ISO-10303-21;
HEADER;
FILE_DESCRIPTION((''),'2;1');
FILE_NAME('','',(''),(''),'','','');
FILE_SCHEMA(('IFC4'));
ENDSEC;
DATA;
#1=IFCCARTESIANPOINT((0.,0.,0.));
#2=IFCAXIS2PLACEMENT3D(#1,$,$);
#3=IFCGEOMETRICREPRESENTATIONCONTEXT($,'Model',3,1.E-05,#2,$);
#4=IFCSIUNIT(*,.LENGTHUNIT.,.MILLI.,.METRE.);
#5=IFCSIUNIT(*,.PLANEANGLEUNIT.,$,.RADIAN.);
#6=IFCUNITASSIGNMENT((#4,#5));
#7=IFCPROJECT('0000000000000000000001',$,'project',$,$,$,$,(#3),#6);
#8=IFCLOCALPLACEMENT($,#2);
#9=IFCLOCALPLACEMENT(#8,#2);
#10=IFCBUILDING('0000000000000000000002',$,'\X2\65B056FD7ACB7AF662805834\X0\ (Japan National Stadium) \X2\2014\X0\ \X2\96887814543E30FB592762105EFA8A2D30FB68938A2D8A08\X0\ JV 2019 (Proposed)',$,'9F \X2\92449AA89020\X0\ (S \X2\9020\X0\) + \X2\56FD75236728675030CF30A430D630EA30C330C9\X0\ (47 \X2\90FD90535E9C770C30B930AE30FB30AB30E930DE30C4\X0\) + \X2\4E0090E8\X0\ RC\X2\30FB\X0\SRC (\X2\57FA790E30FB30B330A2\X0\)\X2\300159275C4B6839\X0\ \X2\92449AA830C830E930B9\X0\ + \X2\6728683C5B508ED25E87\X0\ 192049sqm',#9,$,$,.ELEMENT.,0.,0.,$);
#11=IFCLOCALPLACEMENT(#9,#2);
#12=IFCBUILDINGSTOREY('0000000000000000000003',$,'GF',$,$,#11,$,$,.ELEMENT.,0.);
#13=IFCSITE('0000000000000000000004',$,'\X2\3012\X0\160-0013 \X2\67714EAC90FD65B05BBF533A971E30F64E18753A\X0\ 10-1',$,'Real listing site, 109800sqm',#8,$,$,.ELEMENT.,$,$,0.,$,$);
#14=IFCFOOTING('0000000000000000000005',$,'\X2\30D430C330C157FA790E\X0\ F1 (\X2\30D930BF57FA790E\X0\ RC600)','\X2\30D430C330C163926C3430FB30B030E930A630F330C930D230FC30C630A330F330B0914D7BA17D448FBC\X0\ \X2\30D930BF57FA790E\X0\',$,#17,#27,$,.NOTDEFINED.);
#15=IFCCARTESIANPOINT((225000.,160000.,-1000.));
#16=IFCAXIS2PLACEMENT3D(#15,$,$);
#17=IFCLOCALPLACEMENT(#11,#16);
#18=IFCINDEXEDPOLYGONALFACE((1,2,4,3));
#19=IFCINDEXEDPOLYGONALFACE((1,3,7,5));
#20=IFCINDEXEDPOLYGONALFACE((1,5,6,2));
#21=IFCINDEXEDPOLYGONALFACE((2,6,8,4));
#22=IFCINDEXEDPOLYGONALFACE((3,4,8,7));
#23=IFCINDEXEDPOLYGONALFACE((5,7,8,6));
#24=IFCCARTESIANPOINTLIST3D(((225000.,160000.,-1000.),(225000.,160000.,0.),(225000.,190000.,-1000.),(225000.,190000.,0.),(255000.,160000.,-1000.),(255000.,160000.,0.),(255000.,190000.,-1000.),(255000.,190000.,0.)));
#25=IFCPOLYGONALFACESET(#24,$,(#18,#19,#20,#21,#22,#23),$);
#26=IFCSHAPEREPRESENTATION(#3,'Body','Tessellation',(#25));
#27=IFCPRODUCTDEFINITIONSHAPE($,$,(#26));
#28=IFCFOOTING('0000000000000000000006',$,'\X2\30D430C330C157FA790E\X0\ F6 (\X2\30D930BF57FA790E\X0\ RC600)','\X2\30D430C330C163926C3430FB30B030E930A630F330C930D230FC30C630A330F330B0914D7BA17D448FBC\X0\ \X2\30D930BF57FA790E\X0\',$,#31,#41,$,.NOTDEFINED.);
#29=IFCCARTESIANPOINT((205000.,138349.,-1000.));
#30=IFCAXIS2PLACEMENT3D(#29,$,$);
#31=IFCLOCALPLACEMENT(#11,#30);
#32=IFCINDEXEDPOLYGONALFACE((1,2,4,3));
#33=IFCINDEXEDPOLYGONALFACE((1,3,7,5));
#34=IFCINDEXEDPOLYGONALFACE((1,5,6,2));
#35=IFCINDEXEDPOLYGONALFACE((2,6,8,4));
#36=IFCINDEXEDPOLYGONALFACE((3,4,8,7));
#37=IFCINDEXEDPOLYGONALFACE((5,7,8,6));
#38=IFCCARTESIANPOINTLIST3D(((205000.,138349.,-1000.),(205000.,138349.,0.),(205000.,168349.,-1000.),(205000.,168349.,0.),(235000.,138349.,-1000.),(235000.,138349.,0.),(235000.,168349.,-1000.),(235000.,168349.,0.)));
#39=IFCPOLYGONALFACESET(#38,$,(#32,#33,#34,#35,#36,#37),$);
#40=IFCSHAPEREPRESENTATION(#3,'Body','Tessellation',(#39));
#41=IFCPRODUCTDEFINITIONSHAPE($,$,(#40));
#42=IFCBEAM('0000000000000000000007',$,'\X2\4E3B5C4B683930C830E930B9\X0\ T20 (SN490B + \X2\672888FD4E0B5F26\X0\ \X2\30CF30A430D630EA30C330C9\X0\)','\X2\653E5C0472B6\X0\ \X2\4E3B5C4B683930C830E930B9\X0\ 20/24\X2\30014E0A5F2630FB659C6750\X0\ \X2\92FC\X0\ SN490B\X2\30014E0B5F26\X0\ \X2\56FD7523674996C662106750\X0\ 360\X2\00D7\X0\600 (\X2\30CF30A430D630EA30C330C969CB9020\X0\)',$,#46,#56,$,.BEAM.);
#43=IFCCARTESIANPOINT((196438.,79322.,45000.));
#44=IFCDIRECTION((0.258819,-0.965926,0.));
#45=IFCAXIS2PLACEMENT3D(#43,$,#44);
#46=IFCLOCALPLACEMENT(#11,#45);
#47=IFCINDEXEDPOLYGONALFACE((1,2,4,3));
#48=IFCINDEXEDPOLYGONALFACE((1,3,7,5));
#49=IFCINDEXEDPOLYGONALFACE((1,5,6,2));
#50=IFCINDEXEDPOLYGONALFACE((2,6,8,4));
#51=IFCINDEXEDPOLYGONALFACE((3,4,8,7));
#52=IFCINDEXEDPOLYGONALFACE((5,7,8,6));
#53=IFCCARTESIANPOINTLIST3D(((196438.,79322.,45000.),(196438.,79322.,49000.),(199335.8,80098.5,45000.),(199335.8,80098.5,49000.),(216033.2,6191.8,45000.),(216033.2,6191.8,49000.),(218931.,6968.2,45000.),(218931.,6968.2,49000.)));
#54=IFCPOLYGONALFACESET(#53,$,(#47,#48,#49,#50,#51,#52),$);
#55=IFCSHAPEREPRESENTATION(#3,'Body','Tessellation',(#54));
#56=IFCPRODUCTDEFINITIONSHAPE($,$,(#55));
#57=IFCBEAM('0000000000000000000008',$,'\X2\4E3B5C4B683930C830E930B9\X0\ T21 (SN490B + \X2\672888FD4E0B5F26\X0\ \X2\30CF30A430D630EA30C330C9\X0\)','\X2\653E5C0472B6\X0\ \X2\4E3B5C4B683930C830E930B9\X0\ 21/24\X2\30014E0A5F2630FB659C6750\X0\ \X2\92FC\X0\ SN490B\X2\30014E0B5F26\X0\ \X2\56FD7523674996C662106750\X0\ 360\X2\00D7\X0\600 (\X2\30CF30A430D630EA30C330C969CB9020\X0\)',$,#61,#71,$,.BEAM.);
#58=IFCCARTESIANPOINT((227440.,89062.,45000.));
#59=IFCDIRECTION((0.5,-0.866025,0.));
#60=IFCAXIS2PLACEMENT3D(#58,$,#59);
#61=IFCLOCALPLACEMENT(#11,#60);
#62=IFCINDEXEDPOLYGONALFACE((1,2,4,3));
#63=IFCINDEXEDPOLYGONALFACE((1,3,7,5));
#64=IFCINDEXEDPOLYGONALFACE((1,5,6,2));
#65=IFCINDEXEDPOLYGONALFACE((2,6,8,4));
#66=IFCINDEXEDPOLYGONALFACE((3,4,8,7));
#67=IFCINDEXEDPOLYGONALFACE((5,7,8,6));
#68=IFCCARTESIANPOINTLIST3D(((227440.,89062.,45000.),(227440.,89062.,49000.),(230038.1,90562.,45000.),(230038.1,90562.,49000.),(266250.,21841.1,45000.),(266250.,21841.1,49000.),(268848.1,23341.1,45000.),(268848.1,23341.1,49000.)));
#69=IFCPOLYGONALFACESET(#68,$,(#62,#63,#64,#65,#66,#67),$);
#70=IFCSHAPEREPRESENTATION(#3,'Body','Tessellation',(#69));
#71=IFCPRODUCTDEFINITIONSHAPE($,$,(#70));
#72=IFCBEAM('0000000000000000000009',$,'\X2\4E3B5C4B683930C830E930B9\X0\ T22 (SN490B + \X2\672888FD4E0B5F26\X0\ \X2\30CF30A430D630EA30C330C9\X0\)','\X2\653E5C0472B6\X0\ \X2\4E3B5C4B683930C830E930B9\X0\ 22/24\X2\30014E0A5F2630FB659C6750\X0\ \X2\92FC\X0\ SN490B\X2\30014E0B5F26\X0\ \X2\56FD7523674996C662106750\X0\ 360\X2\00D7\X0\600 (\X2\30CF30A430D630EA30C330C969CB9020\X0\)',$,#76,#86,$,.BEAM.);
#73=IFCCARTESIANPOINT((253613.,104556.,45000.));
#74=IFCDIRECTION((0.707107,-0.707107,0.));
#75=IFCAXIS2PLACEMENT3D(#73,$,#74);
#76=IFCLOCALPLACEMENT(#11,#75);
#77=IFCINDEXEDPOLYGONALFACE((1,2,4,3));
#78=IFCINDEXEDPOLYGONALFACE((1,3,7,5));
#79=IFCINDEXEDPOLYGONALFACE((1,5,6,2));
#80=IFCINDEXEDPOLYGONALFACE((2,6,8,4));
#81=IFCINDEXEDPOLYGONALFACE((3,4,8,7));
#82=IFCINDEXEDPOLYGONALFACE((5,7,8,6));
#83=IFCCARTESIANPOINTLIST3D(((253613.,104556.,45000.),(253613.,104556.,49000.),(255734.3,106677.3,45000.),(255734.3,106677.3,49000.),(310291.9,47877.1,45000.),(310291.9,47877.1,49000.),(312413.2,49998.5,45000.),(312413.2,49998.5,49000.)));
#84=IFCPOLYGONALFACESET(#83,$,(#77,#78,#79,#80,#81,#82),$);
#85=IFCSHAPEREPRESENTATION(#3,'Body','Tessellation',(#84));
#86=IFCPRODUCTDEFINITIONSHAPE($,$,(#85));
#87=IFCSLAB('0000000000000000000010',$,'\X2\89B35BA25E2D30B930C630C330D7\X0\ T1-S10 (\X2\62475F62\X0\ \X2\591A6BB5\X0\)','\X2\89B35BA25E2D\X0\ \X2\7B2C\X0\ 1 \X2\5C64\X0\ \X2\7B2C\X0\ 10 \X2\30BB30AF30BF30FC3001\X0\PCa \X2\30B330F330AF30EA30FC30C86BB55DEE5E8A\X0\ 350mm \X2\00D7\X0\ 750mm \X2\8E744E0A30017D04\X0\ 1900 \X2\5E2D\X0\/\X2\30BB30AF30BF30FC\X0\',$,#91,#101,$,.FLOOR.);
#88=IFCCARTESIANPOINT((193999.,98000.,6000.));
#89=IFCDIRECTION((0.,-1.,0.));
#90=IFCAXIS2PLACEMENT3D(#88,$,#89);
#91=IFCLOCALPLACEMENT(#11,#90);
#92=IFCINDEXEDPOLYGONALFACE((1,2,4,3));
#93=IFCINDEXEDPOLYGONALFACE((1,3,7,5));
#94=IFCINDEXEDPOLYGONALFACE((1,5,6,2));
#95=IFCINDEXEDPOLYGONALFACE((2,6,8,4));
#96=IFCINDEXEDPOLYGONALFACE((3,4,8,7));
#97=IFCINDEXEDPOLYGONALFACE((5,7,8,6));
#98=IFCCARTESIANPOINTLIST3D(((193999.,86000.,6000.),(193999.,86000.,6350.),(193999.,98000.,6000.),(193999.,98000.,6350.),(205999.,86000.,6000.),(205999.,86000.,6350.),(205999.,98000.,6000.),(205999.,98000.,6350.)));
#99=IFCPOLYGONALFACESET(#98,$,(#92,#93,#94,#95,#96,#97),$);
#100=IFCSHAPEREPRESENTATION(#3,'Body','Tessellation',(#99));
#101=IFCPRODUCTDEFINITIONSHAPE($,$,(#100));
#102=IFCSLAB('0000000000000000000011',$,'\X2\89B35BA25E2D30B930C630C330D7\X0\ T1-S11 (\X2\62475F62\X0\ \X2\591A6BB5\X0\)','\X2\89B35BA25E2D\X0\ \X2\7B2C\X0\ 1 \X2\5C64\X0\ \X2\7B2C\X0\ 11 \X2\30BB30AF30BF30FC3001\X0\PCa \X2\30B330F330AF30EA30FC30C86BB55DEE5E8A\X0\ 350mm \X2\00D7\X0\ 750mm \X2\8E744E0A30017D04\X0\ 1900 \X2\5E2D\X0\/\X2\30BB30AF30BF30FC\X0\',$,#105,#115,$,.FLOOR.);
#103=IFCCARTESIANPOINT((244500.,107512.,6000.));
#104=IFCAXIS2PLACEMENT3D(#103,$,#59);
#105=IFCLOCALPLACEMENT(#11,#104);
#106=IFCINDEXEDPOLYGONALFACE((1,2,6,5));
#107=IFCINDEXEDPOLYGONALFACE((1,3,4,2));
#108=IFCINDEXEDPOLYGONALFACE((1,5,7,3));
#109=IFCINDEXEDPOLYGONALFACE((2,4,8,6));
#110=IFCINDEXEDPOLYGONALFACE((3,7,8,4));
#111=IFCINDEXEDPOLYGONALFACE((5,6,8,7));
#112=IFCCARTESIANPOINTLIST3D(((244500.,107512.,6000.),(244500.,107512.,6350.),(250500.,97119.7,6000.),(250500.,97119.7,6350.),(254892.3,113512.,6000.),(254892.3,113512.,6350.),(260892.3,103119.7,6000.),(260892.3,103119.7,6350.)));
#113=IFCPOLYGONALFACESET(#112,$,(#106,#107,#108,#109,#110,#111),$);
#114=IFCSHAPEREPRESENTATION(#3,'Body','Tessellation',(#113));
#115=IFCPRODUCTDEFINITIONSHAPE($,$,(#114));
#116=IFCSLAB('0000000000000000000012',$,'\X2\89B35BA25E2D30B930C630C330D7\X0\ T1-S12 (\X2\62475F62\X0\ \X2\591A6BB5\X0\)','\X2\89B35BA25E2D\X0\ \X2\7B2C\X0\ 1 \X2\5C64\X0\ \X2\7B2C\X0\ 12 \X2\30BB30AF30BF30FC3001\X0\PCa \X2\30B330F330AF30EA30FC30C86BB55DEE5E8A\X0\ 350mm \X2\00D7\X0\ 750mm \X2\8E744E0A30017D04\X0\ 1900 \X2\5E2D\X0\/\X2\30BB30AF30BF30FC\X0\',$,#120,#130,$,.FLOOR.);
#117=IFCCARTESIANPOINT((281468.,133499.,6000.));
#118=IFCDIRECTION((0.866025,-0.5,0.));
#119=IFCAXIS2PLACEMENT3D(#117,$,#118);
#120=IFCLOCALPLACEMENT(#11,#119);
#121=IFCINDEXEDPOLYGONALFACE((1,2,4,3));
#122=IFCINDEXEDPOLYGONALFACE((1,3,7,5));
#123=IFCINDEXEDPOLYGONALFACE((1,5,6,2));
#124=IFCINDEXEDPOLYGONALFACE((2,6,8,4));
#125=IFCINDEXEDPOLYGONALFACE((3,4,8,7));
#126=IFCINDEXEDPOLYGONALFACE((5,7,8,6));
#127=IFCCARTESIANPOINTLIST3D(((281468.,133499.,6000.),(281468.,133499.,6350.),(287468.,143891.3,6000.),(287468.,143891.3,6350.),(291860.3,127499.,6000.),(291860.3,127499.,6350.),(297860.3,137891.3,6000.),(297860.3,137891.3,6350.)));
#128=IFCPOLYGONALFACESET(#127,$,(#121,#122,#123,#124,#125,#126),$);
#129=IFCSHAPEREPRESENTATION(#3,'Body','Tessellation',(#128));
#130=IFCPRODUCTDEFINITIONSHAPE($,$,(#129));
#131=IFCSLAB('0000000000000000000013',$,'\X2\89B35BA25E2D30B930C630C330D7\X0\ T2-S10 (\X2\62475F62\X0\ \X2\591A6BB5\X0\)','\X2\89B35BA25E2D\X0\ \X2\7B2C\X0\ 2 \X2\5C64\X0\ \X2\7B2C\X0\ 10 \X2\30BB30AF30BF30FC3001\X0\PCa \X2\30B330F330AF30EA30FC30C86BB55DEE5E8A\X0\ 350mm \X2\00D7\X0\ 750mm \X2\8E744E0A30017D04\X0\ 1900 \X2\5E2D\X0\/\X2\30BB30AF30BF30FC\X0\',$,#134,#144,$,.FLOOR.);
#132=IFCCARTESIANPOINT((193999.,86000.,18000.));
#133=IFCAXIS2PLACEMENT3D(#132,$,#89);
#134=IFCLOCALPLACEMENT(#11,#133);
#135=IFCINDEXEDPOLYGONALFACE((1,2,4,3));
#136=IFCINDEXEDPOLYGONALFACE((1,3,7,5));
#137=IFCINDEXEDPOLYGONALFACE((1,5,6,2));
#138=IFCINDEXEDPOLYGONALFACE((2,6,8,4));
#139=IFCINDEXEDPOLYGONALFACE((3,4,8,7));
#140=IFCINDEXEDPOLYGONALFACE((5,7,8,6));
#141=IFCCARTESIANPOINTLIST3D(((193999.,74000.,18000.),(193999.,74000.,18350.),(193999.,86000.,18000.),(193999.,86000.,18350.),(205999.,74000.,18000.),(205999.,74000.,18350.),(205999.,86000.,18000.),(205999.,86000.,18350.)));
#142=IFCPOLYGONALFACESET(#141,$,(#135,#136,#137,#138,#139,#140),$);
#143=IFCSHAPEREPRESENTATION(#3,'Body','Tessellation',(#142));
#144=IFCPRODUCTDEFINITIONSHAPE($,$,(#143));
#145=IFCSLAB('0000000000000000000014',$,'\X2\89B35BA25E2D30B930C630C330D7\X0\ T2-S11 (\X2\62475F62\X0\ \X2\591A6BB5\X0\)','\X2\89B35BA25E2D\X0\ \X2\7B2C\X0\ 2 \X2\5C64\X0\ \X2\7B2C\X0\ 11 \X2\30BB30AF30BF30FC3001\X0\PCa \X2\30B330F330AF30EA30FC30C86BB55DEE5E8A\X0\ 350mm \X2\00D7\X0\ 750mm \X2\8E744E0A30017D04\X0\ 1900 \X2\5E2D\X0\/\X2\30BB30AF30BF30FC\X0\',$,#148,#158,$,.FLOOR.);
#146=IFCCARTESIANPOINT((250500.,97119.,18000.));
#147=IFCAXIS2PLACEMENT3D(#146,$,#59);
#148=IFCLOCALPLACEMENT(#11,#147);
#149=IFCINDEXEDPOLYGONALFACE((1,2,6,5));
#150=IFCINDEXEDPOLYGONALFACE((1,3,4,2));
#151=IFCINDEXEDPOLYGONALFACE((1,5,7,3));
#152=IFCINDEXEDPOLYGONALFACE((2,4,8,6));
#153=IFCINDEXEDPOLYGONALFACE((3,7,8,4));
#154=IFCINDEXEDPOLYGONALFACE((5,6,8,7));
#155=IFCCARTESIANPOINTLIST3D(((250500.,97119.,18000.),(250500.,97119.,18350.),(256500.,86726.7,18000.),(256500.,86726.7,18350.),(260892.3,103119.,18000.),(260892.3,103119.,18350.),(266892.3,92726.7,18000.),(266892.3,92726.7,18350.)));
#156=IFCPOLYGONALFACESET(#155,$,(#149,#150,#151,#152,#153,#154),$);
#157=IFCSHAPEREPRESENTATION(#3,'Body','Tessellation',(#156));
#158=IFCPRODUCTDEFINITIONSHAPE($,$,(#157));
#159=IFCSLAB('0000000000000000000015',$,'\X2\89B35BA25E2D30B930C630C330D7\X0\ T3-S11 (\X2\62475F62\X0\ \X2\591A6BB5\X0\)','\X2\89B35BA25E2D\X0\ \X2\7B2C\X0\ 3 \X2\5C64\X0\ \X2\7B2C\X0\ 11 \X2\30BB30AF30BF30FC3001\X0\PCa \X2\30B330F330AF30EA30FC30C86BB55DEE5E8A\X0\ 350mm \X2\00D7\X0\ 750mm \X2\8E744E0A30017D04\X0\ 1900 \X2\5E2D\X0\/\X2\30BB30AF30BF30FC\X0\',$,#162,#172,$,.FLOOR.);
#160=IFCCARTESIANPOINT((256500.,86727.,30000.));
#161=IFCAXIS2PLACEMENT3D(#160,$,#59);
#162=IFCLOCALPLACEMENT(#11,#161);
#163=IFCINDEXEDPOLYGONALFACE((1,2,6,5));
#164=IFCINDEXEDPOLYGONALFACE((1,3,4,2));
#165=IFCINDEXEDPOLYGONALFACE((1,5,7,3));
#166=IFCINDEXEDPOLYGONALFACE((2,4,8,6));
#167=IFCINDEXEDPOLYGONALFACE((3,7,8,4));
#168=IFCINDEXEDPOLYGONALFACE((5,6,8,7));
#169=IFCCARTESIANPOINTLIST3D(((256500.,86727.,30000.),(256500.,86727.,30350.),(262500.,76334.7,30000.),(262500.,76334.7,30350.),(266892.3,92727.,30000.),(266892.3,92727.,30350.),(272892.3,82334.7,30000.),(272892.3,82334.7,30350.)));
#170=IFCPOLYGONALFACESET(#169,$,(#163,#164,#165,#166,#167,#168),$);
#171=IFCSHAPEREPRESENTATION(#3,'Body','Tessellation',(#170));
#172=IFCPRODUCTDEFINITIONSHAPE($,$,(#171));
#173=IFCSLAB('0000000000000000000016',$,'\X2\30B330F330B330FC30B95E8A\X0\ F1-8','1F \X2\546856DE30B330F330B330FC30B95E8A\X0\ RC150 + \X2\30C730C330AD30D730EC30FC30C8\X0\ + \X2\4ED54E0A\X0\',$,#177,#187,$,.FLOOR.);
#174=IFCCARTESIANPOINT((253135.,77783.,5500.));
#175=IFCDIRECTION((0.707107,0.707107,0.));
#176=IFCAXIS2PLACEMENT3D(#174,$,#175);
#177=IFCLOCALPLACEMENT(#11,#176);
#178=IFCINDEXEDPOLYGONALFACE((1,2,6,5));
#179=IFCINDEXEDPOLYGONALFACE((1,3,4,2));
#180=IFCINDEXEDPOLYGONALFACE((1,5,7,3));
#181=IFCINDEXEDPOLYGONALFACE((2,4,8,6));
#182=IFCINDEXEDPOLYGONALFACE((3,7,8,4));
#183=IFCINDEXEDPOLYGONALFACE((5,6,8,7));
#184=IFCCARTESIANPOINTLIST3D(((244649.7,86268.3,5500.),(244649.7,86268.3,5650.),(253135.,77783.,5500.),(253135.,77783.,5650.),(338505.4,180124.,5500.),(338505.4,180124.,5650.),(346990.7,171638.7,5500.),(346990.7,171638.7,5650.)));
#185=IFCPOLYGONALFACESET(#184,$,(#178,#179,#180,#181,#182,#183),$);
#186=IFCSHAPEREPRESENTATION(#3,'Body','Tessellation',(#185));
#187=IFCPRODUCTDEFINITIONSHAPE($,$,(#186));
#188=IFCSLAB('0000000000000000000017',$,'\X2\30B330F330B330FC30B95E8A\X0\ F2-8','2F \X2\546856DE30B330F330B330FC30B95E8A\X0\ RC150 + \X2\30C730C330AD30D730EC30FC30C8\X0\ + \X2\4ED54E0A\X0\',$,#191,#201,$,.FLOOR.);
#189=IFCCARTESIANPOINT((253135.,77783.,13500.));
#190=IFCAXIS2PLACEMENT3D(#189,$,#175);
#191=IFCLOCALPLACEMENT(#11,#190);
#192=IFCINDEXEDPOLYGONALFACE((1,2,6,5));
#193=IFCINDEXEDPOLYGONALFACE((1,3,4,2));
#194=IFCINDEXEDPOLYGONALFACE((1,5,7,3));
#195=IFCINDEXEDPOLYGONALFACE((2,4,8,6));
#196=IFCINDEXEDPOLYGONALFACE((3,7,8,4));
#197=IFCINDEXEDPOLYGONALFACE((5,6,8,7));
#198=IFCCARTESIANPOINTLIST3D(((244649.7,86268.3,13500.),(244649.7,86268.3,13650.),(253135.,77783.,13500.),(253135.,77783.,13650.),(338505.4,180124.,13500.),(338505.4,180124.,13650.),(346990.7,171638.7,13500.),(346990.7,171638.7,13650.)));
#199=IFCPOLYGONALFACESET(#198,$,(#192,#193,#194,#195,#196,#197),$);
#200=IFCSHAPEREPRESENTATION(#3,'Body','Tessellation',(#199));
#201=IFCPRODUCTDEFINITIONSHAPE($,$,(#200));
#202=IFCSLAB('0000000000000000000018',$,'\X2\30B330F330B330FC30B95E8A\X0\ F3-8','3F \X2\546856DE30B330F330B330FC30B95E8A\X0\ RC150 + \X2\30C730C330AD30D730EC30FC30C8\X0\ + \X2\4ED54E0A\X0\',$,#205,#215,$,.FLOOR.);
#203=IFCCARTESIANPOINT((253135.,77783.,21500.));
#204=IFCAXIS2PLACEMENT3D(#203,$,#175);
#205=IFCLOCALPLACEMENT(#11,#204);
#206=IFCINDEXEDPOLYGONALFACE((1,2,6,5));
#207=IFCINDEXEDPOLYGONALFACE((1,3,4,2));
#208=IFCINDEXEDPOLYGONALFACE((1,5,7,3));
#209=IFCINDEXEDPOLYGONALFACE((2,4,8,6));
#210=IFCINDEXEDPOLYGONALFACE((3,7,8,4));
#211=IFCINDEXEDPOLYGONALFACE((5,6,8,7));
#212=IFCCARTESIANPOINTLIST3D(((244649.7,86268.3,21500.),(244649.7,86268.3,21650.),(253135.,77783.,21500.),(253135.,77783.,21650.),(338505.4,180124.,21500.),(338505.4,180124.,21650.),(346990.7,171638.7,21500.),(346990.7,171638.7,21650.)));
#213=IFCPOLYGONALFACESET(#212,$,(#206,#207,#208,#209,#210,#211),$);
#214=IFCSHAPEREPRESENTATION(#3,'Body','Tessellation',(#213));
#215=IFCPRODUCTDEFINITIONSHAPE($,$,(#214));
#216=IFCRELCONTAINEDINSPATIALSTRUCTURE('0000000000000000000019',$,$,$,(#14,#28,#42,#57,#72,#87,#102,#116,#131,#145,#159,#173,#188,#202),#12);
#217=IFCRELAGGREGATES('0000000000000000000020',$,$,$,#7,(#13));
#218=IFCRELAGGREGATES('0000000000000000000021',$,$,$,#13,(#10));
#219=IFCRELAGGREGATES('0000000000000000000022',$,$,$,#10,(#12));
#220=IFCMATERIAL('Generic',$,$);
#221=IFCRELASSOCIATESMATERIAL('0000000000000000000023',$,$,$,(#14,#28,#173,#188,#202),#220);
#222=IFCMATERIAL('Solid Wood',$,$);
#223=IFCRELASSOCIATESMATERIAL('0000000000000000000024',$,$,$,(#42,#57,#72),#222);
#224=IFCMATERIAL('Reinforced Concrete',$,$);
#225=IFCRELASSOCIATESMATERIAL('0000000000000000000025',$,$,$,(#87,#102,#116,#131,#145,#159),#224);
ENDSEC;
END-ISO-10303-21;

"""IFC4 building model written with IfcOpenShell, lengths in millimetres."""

from ifc_helpers import new_model, si_unit, frame, frame_2d, origin, place, context, project, spatial, rectangle, extrude, material, element, save


model = new_model("IFC4")

# Units and contexts
model_context = context("Model", 3, precision=1e-05, world=origin())
ifc_project = project(units=[si_unit("LENGTHUNIT", "METRE", prefix="MILLI"), si_unit("PLANEANGLEUNIT", "RADIAN")], contexts=[model_context])

# Site, building, storey
site_placement = place(None, origin())
site = spatial("IfcSite", under=ifc_project, at=site_placement, Name="〒160-0013 東京都新宿区霞ヶ丘町 10-1", ObjectType="Real listing site, 109800sqm", CompositionType="ELEMENT", RefElevation=0.0)
building_placement = place(site_placement, origin())
building = spatial("IfcBuilding", under=site, at=building_placement, Name="新国立競技場 (Japan National Stadium) — 隈研吾・大成建設・梓設計 JV 2019 (Proposed)", ObjectType="9F 鉄骨造 (S 造) + 国産木材ハイブリッド (47 都道府県スギ・カラマツ) + 一部 RC・SRC (基礎・コア)、大屋根 鉄骨トラス + 木格子軒庇 192049sqm", CompositionType="ELEMENT", ElevationOfRefHeight=0.0, ElevationOfTerrain=0.0)
storey_placement = place(building_placement, origin())
storey = spatial("IfcBuildingStorey", under=building, at=storey_placement, Name="GF", CompositionType="ELEMENT", Elevation=0.0)

# Footings
ifc_material_1 = material(Name="Generic")
footing_1_placement = place(storey_placement, frame((225000.0, 160000.0, -1000.0)))
element("IfcFooting", 1, at=footing_1_placement, inside=storey, material=ifc_material_1, Name="ピッチ基礎 F1 (ベタ基礎 RC600)", Description="ピッチ排水・グラウンドヒーティング配管組込 ベタ基礎", PredefinedType="NOTDEFINED", context=model_context, shape_type="SweptSolid", body=[
    extrude(rectangle(XDim=30000.0, YDim=30000.0, at=frame_2d((15000.0, 15000.0))), frame((225000.0, 160000.0, -1000.0)), (0.0, 0.0, 1.0), 1000.0),
])
footing_2_placement = place(storey_placement, frame((205000.0, 138349.0, -1000.0)))
element("IfcFooting", 2, at=footing_2_placement, inside=storey, material=ifc_material_1, Name="ピッチ基礎 F6 (ベタ基礎 RC600)", Description="ピッチ排水・グラウンドヒーティング配管組込 ベタ基礎", PredefinedType="NOTDEFINED", context=model_context, shape_type="SweptSolid", body=[
    extrude(rectangle(XDim=30000.0, YDim=30000.0, at=frame_2d((15000.0, 15000.0))), frame((205000.0, 138349.0, -1000.0)), (0.0, 0.0, 1.0), 1000.0),
])

# Beams
ifc_material_2 = material(Name="Solid Wood")
beam_1_placement = place(storey_placement, frame((196438.0, 79322.0, 45000.0), x_axis=(0.258819, -0.965926, 0.0)))
element("IfcBeam", 3, at=beam_1_placement, inside=storey, material=ifc_material_2, Name="主屋根トラス T20 (SN490B + 木製下弦 ハイブリッド)", Description="放射状 主屋根トラス 20/24、上弦・斜材 鋼 SN490B、下弦 国産杉集成材 360×600 (ハイブリッド構造)", PredefinedType="BEAM", context=model_context, shape_type="SweptSolid", body=[
    extrude(rectangle(XDim=75710.0, YDim=3000.0, at=frame_2d((37855.0, 1500.0))), frame((196438.0, 79322.0, 45000.0), x_axis=(0.258819, -0.965926, 0.0)), (0.0, 0.0, 1.0), 4000.0),
])
beam_2_placement = place(storey_placement, frame((227440.0, 89062.0, 45000.0), x_axis=(0.5, -0.866025, 0.0)))
element("IfcBeam", 4, at=beam_2_placement, inside=storey, material=ifc_material_2, Name="主屋根トラス T21 (SN490B + 木製下弦 ハイブリッド)", Description="放射状 主屋根トラス 21/24、上弦・斜材 鋼 SN490B、下弦 国産杉集成材 360×600 (ハイブリッド構造)", PredefinedType="BEAM", context=model_context, shape_type="SweptSolid", body=[
    extrude(rectangle(XDim=77620.0, YDim=3000.0, at=frame_2d((38810.0, 1500.0))), frame((227440.0, 89062.0, 45000.0), x_axis=(0.5, -0.866025, 0.0)), (0.0, 0.0, 1.0), 4000.0),
])
beam_3_placement = place(storey_placement, frame((253613.0, 104556.0, 45000.0), x_axis=(0.707107, -0.707107, 0.0)))
element("IfcBeam", 5, at=beam_3_placement, inside=storey, material=ifc_material_2, Name="主屋根トラス T22 (SN490B + 木製下弦 ハイブリッド)", Description="放射状 主屋根トラス 22/24、上弦・斜材 鋼 SN490B、下弦 国産杉集成材 360×600 (ハイブリッド構造)", PredefinedType="BEAM", context=model_context, shape_type="SweptSolid", body=[
    extrude(rectangle(XDim=80156.0, YDim=3000.0, at=frame_2d((40078.0, 1500.0))), frame((253613.0, 104556.0, 45000.0), x_axis=(0.707107, -0.707107, 0.0)), (0.0, 0.0, 1.0), 4000.0),
])

# Slabs
ifc_material_3 = material(Name="Reinforced Concrete")
slab_1_placement = place(storey_placement, frame((193999.0, 98000.0, 6000.0), x_axis=(0.0, -1.0, 0.0)))
element("IfcSlab", 6, at=slab_1_placement, inside=storey, material=ifc_material_3, Name="観客席ステップ T1-S10 (扇形 多段)", Description="観客席 第 1 層 第 10 セクター、PCa コンクリート段差床 350mm × 750mm 蹴上、約 1900 席/セクター", PredefinedType="FLOOR", context=model_context, shape_type="SweptSolid", body=[
    extrude(rectangle(XDim=12000.0, YDim=12000.0, at=frame_2d((6000.0, 6000.0))), frame((193999.0, 98000.0, 6000.0), x_axis=(0.0, -1.0, 0.0)), (0.0, 0.0, 1.0), 350.0),
])
slab_2_placement = place(storey_placement, frame((244500.0, 107512.0, 6000.0), x_axis=(0.5, -0.866025, 0.0)))
element("IfcSlab", 7, at=slab_2_placement, inside=storey, material=ifc_material_3, Name="観客席ステップ T1-S11 (扇形 多段)", Description="観客席 第 1 層 第 11 セクター、PCa コンクリート段差床 350mm × 750mm 蹴上、約 1900 席/セクター", PredefinedType="FLOOR", context=model_context, shape_type="SweptSolid", body=[
    extrude(rectangle(XDim=12000.0, YDim=12000.0, at=frame_2d((6000.0, 6000.0))), frame((244500.0, 107512.0, 6000.0), x_axis=(0.5, -0.866025, 0.0)), (0.0, 0.0, 1.0), 350.0),
])
slab_3_placement = place(storey_placement, frame((281468.0, 133499.0, 6000.0), x_axis=(0.866025, -0.5, 0.0)))
element("IfcSlab", 8, at=slab_3_placement, inside=storey, material=ifc_material_3, Name="観客席ステップ T1-S12 (扇形 多段)", Description="観客席 第 1 層 第 12 セクター、PCa コンクリート段差床 350mm × 750mm 蹴上、約 1900 席/セクター", PredefinedType="FLOOR", context=model_context, shape_type="SweptSolid", body=[
    extrude(rectangle(XDim=12000.0, YDim=12000.0, at=frame_2d((6000.0, 6000.0))), frame((281468.0, 133499.0, 6000.0), x_axis=(0.866025, -0.5, 0.0)), (0.0, 0.0, 1.0), 350.0),
])
slab_4_placement = place(storey_placement, frame((193999.0, 86000.0, 18000.0), x_axis=(0.0, -1.0, 0.0)))
element("IfcSlab", 9, at=slab_4_placement, inside=storey, material=ifc_material_3, Name="観客席ステップ T2-S10 (扇形 多段)", Description="観客席 第 2 層 第 10 セクター、PCa コンクリート段差床 350mm × 750mm 蹴上、約 1900 席/セクター", PredefinedType="FLOOR", context=model_context, shape_type="SweptSolid", body=[
    extrude(rectangle(XDim=12000.0, YDim=12000.0, at=frame_2d((6000.0, 6000.0))), frame((193999.0, 86000.0, 18000.0), x_axis=(0.0, -1.0, 0.0)), (0.0, 0.0, 1.0), 350.0),
])
slab_5_placement = place(storey_placement, frame((250500.0, 97119.0, 18000.0), x_axis=(0.5, -0.866025, 0.0)))
element("IfcSlab", 10, at=slab_5_placement, inside=storey, material=ifc_material_3, Name="観客席ステップ T2-S11 (扇形 多段)", Description="観客席 第 2 層 第 11 セクター、PCa コンクリート段差床 350mm × 750mm 蹴上、約 1900 席/セクター", PredefinedType="FLOOR", context=model_context, shape_type="SweptSolid", body=[
    extrude(rectangle(XDim=12000.0, YDim=12000.0, at=frame_2d((6000.0, 6000.0))), frame((250500.0, 97119.0, 18000.0), x_axis=(0.5, -0.866025, 0.0)), (0.0, 0.0, 1.0), 350.0),
])
slab_6_placement = place(storey_placement, frame((256500.0, 86727.0, 30000.0), x_axis=(0.5, -0.866025, 0.0)))
element("IfcSlab", 11, at=slab_6_placement, inside=storey, material=ifc_material_3, Name="観客席ステップ T3-S11 (扇形 多段)", Description="観客席 第 3 層 第 11 セクター、PCa コンクリート段差床 350mm × 750mm 蹴上、約 1900 席/セクター", PredefinedType="FLOOR", context=model_context, shape_type="SweptSolid", body=[
    extrude(rectangle(XDim=12000.0, YDim=12000.0, at=frame_2d((6000.0, 6000.0))), frame((256500.0, 86727.0, 30000.0), x_axis=(0.5, -0.866025, 0.0)), (0.0, 0.0, 1.0), 350.0),
])
slab_7_placement = place(storey_placement, frame((253135.0, 77783.0, 5500.0), x_axis=(0.707107, 0.707107, 0.0)))
element("IfcSlab", 12, at=slab_7_placement, inside=storey, material=ifc_material_1, Name="コンコース床 F1-8", Description="1F 周回コンコース床 RC150 + デッキプレート + 仕上", PredefinedType="FLOOR", context=model_context, shape_type="SweptSolid", body=[
    extrude(rectangle(XDim=132732.0, YDim=12000.0, at=frame_2d((66366.0, 6000.0))), frame((253135.0, 77783.0, 5500.0), x_axis=(0.707107, 0.707107, 0.0)), (0.0, 0.0, 1.0), 150.0),
])
slab_8_placement = place(storey_placement, frame((253135.0, 77783.0, 13500.0), x_axis=(0.707107, 0.707107, 0.0)))
element("IfcSlab", 13, at=slab_8_placement, inside=storey, material=ifc_material_1, Name="コンコース床 F2-8", Description="2F 周回コンコース床 RC150 + デッキプレート + 仕上", PredefinedType="FLOOR", context=model_context, shape_type="SweptSolid", body=[
    extrude(rectangle(XDim=132732.0, YDim=12000.0, at=frame_2d((66366.0, 6000.0))), frame((253135.0, 77783.0, 13500.0), x_axis=(0.707107, 0.707107, 0.0)), (0.0, 0.0, 1.0), 150.0),
])
slab_9_placement = place(storey_placement, frame((253135.0, 77783.0, 21500.0), x_axis=(0.707107, 0.707107, 0.0)))
element("IfcSlab", 14, at=slab_9_placement, inside=storey, material=ifc_material_1, Name="コンコース床 F3-8", Description="3F 周回コンコース床 RC150 + デッキプレート + 仕上", PredefinedType="FLOOR", context=model_context, shape_type="SweptSolid", body=[
    extrude(rectangle(XDim=132732.0, YDim=12000.0, at=frame_2d((66366.0, 6000.0))), frame((253135.0, 77783.0, 21500.0), x_axis=(0.707107, 0.707107, 0.0)), (0.0, 0.0, 1.0), 150.0),
])

save(model, "model.ifc")
